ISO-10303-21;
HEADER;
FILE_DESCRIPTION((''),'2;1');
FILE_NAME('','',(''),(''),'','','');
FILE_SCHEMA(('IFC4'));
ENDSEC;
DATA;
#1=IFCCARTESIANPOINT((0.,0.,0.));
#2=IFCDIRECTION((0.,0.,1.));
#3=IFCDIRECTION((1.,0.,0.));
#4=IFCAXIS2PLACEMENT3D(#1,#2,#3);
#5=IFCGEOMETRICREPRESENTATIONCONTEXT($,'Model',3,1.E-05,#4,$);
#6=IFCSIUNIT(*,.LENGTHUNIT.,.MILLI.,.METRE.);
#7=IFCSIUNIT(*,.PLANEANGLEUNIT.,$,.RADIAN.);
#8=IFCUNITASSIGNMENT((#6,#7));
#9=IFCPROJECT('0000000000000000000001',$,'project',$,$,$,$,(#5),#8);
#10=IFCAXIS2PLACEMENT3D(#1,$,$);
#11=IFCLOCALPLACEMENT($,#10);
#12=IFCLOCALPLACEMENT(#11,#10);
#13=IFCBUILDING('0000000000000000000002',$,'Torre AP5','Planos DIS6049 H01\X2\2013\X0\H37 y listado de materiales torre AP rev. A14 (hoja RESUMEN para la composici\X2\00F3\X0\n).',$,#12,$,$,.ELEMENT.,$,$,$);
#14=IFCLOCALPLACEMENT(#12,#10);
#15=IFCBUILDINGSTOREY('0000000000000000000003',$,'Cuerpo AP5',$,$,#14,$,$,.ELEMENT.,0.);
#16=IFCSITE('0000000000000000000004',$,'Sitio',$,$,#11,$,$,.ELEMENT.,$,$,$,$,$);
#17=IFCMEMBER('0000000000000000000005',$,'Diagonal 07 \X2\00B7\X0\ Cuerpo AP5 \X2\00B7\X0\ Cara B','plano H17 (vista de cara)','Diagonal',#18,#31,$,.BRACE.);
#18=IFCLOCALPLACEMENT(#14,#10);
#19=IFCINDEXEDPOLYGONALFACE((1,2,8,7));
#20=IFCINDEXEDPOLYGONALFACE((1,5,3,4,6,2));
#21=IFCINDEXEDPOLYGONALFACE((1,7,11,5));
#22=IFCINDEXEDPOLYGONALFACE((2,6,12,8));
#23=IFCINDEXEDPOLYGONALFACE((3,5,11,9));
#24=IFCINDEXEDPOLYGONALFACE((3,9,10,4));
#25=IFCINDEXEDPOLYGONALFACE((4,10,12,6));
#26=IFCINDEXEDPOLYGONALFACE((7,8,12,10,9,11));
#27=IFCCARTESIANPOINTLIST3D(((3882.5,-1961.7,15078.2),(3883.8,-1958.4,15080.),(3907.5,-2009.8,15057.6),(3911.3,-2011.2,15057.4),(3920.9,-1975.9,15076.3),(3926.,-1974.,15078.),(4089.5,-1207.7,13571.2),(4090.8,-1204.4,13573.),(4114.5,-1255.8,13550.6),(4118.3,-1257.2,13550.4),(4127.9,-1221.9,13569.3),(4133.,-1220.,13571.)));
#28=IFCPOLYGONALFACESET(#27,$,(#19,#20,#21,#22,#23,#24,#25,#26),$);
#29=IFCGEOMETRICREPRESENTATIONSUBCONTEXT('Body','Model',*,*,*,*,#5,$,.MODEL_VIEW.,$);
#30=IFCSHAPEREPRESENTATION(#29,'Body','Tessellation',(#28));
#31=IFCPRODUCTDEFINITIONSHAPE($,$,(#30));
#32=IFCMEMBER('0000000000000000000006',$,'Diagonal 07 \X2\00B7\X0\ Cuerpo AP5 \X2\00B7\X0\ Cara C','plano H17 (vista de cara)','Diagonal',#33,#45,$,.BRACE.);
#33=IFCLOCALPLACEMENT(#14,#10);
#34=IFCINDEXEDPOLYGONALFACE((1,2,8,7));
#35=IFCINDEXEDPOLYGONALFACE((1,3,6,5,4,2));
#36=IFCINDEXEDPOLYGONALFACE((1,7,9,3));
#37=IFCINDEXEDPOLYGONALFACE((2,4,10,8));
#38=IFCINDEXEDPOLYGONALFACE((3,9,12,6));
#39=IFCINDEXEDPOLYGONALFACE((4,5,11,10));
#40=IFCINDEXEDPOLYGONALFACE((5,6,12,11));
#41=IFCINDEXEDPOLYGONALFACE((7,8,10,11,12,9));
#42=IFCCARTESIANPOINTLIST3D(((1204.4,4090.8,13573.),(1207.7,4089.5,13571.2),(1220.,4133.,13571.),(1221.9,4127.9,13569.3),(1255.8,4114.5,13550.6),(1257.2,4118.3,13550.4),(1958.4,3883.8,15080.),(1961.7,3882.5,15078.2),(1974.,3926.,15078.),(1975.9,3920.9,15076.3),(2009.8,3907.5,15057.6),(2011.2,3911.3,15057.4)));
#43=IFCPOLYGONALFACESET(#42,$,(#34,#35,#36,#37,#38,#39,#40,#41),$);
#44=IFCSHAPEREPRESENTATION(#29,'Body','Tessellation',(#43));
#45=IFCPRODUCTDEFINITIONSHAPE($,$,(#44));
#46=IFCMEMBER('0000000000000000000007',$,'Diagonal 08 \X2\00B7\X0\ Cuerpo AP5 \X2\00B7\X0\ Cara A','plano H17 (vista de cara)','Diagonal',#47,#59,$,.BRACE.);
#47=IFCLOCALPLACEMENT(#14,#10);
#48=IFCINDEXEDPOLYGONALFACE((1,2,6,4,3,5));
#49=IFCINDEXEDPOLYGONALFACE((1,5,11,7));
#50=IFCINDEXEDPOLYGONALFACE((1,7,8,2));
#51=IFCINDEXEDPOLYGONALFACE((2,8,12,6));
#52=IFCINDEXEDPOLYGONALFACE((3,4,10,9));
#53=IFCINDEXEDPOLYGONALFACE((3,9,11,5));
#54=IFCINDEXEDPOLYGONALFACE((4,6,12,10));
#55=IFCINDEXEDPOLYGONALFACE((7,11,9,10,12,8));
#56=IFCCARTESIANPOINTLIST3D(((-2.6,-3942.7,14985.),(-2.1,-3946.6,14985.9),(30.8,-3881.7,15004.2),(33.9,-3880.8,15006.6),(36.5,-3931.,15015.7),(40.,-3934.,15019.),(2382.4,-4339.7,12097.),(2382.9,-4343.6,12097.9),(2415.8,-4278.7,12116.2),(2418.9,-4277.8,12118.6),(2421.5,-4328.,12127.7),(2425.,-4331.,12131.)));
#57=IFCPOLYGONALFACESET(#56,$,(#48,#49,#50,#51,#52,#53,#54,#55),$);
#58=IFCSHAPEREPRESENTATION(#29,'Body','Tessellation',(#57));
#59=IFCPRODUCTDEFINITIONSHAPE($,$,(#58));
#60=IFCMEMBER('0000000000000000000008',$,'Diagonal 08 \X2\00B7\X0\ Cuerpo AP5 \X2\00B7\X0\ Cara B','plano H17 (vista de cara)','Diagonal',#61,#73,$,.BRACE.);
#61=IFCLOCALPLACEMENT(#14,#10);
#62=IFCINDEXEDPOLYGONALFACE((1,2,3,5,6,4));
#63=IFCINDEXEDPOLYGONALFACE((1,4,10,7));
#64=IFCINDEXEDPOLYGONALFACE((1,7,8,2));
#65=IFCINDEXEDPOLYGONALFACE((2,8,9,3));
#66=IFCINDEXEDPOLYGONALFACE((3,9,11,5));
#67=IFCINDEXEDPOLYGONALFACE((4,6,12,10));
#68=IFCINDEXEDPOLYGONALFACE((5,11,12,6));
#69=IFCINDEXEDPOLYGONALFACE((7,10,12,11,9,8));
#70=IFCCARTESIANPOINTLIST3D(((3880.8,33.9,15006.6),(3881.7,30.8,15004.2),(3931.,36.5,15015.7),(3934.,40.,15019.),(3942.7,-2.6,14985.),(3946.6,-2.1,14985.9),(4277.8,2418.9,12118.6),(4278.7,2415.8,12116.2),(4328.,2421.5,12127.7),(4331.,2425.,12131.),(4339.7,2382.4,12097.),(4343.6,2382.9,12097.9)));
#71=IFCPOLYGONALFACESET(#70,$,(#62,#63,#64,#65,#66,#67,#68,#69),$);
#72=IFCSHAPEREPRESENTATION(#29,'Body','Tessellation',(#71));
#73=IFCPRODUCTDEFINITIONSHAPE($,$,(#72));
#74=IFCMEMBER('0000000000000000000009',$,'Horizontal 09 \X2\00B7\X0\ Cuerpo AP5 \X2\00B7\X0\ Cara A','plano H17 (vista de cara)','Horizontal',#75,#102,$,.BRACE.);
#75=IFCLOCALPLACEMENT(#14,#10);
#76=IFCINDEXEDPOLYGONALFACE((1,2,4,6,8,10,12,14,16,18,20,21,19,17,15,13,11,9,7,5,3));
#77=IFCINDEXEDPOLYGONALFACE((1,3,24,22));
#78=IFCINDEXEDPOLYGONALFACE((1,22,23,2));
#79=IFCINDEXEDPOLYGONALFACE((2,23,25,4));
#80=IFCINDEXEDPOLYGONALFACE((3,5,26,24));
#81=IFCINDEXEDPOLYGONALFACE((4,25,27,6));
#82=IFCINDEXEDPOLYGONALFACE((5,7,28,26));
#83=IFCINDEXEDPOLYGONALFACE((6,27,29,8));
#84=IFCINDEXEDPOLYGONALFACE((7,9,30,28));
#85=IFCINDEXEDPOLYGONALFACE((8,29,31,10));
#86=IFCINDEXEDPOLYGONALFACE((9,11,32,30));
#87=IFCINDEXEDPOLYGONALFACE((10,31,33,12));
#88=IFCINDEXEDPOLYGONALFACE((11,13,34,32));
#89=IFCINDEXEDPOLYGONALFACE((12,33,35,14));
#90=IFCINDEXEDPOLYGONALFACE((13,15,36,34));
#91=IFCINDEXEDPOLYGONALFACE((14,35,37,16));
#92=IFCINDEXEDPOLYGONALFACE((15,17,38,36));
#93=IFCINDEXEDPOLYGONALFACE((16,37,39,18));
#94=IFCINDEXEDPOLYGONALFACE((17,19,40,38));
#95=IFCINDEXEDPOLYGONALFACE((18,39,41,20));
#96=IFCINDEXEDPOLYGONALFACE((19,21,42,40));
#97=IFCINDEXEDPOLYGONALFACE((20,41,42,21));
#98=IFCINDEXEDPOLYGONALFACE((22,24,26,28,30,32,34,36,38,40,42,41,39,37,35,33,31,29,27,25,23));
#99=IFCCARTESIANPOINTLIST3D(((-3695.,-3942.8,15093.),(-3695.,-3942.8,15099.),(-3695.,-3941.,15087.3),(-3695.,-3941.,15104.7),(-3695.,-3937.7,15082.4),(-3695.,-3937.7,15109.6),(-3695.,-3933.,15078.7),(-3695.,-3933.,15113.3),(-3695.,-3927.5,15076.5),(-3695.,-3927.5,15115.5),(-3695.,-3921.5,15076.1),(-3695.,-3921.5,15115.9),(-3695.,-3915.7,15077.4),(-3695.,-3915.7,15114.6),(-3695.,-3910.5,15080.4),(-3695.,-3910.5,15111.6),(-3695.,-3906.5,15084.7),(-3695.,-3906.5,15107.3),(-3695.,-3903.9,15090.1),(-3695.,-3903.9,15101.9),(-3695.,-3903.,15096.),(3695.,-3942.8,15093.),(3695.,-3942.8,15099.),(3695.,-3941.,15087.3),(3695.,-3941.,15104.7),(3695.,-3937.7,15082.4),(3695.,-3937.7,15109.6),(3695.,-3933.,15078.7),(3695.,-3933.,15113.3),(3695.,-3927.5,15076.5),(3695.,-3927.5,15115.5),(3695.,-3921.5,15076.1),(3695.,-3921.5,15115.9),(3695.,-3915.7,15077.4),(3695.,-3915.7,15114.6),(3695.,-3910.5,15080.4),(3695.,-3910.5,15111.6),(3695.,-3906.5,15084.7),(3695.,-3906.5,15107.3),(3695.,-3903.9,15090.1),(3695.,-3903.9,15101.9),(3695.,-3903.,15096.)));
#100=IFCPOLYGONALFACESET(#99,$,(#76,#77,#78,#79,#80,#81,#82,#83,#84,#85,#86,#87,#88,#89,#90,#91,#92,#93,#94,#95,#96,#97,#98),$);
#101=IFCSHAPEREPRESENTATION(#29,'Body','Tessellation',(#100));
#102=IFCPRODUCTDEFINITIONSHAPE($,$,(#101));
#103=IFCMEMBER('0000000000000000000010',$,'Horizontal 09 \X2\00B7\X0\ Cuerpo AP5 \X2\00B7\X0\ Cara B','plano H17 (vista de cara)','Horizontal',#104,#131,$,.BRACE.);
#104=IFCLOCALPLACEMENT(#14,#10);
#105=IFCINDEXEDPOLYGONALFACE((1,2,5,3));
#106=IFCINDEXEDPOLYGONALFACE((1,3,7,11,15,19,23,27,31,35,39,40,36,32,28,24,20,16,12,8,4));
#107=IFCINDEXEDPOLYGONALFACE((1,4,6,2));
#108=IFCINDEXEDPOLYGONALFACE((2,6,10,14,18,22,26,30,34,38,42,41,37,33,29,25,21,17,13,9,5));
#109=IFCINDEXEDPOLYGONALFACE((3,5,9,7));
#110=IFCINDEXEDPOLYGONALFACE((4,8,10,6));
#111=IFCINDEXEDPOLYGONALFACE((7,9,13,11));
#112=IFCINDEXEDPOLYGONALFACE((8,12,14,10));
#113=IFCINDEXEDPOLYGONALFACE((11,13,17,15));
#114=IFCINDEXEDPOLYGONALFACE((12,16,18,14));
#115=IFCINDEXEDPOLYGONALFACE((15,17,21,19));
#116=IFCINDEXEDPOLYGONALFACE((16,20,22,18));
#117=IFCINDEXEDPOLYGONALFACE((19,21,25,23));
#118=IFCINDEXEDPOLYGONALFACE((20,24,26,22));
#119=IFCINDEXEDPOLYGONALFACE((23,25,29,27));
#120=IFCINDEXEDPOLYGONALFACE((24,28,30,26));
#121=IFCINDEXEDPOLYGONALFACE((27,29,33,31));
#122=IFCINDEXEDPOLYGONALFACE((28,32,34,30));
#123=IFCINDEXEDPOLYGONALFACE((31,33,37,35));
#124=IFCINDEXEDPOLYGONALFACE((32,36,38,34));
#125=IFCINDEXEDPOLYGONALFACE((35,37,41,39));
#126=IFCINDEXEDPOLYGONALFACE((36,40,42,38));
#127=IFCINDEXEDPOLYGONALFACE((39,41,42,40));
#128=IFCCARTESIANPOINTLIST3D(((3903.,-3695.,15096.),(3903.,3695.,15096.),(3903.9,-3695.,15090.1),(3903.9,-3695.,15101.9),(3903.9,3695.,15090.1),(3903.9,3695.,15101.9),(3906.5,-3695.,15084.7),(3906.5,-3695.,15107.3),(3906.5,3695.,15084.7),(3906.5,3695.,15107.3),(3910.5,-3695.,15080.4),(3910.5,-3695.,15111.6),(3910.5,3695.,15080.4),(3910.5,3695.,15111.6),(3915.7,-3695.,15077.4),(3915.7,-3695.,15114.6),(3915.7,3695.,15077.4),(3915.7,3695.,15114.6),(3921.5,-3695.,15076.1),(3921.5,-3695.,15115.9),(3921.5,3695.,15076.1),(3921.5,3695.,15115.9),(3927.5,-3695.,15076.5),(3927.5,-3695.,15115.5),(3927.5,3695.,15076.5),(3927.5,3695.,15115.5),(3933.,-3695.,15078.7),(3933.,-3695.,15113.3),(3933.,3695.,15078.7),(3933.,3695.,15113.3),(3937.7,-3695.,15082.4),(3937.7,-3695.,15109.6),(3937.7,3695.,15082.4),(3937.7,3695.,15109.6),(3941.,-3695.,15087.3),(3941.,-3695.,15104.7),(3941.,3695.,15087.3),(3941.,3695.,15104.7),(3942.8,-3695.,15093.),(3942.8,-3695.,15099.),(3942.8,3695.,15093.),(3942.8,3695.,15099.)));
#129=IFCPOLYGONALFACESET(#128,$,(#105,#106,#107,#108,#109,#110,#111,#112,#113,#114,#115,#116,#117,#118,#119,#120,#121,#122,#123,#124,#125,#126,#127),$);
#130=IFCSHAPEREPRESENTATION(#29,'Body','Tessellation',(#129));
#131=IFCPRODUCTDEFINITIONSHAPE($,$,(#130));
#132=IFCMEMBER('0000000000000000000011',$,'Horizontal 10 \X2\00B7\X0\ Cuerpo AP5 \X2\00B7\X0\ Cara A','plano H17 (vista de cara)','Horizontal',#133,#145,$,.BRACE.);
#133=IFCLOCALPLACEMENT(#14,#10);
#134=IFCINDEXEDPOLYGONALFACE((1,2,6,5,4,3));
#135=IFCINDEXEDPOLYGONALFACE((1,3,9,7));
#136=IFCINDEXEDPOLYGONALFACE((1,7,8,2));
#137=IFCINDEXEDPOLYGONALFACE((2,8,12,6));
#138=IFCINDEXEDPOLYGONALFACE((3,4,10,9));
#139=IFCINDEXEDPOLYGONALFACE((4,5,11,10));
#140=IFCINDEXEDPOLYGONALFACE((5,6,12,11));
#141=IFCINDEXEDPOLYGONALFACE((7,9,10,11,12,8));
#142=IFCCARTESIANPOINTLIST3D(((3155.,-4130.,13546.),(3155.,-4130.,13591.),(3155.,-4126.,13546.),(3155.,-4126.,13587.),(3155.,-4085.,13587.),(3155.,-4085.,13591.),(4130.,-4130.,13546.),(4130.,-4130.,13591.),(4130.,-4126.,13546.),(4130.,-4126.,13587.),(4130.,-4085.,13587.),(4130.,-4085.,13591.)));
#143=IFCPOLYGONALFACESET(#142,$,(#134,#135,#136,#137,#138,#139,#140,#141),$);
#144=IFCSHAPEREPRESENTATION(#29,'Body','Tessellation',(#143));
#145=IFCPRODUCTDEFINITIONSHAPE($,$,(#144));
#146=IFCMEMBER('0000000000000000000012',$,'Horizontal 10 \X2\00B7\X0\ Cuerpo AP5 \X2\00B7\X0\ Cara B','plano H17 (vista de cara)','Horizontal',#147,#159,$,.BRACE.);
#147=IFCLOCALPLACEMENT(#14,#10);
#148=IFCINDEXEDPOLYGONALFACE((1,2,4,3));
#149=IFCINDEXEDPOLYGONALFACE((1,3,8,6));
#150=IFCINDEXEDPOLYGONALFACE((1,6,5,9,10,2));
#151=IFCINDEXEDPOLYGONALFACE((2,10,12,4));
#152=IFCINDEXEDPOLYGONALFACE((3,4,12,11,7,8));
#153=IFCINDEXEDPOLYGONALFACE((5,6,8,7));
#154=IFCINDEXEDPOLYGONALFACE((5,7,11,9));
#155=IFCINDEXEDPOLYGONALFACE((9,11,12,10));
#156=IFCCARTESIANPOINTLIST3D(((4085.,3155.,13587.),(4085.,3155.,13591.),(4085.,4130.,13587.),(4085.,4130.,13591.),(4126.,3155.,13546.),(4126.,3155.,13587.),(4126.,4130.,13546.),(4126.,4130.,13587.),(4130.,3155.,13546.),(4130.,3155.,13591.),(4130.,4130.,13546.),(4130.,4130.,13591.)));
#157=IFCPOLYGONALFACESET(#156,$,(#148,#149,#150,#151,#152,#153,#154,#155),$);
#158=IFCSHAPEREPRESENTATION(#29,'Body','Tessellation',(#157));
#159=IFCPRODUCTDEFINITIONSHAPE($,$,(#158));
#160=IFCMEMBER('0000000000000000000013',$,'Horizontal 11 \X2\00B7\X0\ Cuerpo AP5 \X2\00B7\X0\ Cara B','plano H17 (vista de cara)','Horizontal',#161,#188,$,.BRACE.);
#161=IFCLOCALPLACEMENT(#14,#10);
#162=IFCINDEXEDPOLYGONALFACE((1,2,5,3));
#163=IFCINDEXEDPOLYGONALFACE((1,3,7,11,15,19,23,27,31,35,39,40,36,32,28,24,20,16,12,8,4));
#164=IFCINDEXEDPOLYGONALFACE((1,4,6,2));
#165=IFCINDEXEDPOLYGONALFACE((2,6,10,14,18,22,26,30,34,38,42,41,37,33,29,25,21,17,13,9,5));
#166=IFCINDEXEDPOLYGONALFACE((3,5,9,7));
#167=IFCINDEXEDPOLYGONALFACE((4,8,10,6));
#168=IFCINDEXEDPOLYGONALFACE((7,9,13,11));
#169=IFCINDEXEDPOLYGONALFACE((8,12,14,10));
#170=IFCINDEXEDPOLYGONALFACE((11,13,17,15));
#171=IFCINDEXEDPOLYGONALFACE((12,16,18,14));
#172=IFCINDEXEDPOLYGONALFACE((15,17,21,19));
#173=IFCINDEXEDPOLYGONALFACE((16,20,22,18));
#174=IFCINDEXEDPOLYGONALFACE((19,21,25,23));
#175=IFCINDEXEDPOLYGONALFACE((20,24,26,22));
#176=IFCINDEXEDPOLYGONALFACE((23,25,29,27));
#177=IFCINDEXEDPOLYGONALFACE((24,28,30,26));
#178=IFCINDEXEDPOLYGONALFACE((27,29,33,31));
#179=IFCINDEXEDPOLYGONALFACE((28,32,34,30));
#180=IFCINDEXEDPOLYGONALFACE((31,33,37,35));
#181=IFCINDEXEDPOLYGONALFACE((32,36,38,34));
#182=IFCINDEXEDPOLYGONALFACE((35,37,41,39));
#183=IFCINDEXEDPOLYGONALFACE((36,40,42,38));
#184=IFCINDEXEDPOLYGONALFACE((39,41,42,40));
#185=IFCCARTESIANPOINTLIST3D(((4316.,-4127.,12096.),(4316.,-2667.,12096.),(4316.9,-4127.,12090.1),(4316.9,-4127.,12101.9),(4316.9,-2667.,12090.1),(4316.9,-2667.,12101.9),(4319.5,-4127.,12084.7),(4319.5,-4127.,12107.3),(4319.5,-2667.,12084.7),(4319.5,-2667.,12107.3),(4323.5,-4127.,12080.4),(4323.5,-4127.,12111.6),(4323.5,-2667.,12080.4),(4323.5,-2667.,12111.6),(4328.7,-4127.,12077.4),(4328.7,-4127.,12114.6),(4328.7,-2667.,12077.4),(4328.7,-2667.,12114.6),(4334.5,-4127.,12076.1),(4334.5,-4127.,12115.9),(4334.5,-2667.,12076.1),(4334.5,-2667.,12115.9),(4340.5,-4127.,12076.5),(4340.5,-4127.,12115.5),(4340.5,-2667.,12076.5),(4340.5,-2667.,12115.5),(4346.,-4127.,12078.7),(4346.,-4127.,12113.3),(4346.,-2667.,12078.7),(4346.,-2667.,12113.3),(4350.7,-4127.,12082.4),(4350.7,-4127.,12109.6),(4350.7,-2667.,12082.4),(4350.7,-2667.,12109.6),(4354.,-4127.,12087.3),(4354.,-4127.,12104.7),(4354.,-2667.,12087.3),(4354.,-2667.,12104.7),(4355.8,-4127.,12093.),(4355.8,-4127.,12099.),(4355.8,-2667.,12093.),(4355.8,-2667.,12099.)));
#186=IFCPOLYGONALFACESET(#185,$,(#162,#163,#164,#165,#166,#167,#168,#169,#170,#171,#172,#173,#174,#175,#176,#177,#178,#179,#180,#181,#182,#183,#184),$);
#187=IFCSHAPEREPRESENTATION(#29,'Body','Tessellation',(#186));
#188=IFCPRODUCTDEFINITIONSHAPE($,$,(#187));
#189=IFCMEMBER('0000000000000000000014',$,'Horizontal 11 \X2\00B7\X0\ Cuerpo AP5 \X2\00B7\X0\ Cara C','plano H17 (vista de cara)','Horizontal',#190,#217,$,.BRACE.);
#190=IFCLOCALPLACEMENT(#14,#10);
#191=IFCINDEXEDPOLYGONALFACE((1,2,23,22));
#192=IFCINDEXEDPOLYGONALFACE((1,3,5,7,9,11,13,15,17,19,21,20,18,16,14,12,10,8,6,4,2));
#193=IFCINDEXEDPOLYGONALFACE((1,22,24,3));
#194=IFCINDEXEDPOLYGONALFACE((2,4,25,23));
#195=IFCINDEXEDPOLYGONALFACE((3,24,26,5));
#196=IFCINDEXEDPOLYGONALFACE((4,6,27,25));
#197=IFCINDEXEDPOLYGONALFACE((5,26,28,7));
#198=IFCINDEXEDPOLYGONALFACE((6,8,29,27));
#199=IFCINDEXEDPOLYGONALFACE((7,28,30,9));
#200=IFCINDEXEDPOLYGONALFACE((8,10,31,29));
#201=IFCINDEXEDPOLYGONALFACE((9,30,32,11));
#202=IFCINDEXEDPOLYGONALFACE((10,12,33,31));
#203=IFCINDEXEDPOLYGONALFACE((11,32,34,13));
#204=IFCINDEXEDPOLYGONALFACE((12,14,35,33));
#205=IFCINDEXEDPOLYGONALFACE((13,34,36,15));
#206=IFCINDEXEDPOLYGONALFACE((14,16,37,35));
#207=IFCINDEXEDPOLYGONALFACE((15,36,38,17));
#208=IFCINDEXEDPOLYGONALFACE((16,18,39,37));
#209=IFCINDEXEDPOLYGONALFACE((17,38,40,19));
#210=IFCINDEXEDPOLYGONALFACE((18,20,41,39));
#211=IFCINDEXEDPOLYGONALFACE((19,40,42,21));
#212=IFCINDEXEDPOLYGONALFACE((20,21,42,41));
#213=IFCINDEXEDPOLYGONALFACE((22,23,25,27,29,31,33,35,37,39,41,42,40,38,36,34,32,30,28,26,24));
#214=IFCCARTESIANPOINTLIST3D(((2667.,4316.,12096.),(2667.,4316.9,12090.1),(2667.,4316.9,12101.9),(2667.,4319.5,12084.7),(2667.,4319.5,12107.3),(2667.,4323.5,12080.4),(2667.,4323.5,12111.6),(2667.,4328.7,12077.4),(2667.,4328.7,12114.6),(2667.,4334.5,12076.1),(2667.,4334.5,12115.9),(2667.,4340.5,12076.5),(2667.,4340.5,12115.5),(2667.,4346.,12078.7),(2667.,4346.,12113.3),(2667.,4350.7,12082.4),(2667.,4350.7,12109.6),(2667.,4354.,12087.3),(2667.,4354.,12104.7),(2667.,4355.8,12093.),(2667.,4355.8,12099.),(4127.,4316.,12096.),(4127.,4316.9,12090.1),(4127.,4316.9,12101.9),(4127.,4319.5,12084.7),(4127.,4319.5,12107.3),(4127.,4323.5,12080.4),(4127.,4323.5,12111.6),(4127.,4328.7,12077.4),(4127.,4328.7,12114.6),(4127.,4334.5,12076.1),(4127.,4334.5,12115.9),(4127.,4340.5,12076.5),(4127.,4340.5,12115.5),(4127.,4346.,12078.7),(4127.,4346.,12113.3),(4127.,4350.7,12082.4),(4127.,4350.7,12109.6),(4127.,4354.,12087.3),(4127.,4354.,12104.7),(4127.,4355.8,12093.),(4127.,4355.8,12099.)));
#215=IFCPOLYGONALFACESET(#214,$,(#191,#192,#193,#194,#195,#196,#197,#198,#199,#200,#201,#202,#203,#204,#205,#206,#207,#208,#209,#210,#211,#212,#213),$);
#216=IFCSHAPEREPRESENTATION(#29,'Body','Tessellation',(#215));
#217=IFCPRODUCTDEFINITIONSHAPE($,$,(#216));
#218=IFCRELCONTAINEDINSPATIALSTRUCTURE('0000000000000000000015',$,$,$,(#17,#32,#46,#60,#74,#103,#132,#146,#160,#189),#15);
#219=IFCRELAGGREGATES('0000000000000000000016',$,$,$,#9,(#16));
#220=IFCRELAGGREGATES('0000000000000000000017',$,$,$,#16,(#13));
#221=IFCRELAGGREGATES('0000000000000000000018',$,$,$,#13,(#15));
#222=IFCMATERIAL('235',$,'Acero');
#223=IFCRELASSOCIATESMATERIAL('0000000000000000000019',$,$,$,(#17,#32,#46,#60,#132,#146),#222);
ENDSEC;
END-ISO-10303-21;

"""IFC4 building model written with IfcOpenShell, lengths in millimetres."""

from ifc_helpers import new_model, si_unit, frame, frame_2d, origin, origin_with_axes, place, context, subcontext, project, spatial, circle, l_section, extrude, material, element, save


model = new_model("IFC4")

# Units and contexts
model_context = context("Model", 3, precision=1e-05, world=origin_with_axes())
body_context = subcontext(model_context, "Body", "Model", "MODEL_VIEW")
ifc_project = project(units=[si_unit("LENGTHUNIT", "METRE", prefix="MILLI"), si_unit("PLANEANGLEUNIT", "RADIAN")], contexts=[model_context])

# Site, building, storey
site_placement = place(None, origin())
site = spatial("IfcSite", under=ifc_project, at=site_placement, Name="Sitio", CompositionType="ELEMENT")
building_placement = place(site_placement, origin())
building = spatial("IfcBuilding", under=site, at=building_placement, Name="Torre AP5", Description="Planos DIS6049 H01–H37 y listado de materiales torre AP rev. A14 (hoja RESUMEN para la composición).", CompositionType="ELEMENT")
storey_placement = place(building_placement, origin())
storey = spatial("IfcBuildingStorey", under=building, at=storey_placement, Name="Cuerpo AP5", CompositionType="ELEMENT", Elevation=0.0)

# Members
ifc_material_1 = material(Name="235", Category="Acero")
for number, where, z_axis, x_axis, name in (
    (1, (4133.0, -1220.0, 13571.0), (-0.121925, -0.444113, 0.887636), (-0.936966, 0.346552, 0.04469), "Diagonal 07 · Cuerpo AP5 · Cara B"),
    (2, (1220.0, 4133.0, 13571.0), (0.444113, -0.121925, 0.887636), (-0.346552, -0.936966, 0.04469), "Diagonal 07 · Cuerpo AP5 · Cara C"),
):
    element("IfcMember", number, at=place(storey_placement, frame(where, z_axis=z_axis, x_axis=x_axis)), inside=storey, material=ifc_material_1, Name=name, Description="plano H17 (vista de cara)", ObjectType="Diagonal", PredefinedType="BRACE", context=body_context, shape_type="SweptSolid", body=[
        extrude(l_section(Depth=45.0, Width=45.0, Thickness=4.0, at=frame_2d((22.5, 22.5))), None, (0.0, 0.0, 1.0), 1697.8),
    ])
for number, where, z_axis, x_axis, name in (
    (3, (2425.0, -4331.0, 12131.0), (-0.633217, 0.105403, 0.766763), (-0.111785, 0.967841, -0.22536), "Diagonal 08 · Cuerpo AP5 · Cara A"),
    (4, (4331.0, 2425.0, 12131.0), (-0.105403, -0.633217, 0.766763), (-0.967841, -0.111785, -0.22536), "Diagonal 08 · Cuerpo AP5 · Cara B"),
):
    element("IfcMember", number, at=place(storey_placement, frame(where, z_axis=z_axis, x_axis=x_axis)), inside=storey, material=ifc_material_1, Name=name, Description="plano H17 (vista de cara)", ObjectType="Diagonal", PredefinedType="BRACE", context=body_context, shape_type="SweptSolid", body=[
        extrude(l_section(Depth=55.0, Width=55.0, Thickness=4.0, at=frame_2d((27.5, 27.5))), None, (0.0, 0.0, 1.0), 3766.5),
    ])
for number, where, z_axis, x_axis, name in (
    (5, (3695.0, -3923.0, 15096.0), (-1.0, 0.0, 0.0), (0.0, 1.0, 0.0), "Horizontal 09 · Cuerpo AP5 · Cara A"),
    (6, (3923.0, 3695.0, 15096.0), (0.0, -1.0, 0.0), (-1.0, 0.0, 0.0), "Horizontal 09 · Cuerpo AP5 · Cara B"),
):
    element("IfcMember", number, at=place(storey_placement, frame(where, z_axis=z_axis, x_axis=x_axis)), inside=storey, Name=name, Description="plano H17 (vista de cara)", ObjectType="Horizontal", PredefinedType="BRACE", context=body_context, shape_type="SweptSolid", body=[
        extrude(circle(Radius=20.0), None, (0.0, 0.0, 1.0), 7390.0),
    ])
for number, where, z_axis, x_axis, name in (
    (7, (4130.0, -4130.0, 13591.0), (-1.0, 0.0, 0.0), (0.0, 1.0, 0.0), "Horizontal 10 · Cuerpo AP5 · Cara A"),
    (8, (4130.0, 4130.0, 13591.0), (0.0, -1.0, 0.0), (-1.0, 0.0, 0.0), "Horizontal 10 · Cuerpo AP5 · Cara B"),
):
    element("IfcMember", number, at=place(storey_placement, frame(where, z_axis=z_axis, x_axis=x_axis)), inside=storey, material=ifc_material_1, Name=name, Description="plano H17 (vista de cara)", ObjectType="Horizontal", PredefinedType="BRACE", context=body_context, shape_type="SweptSolid", body=[
        extrude(l_section(Depth=45.0, Width=45.0, Thickness=4.0, at=frame_2d((22.5, 22.5))), None, (0.0, 0.0, 1.0), 975.0),
    ])
for number, where, z_axis, x_axis, name in (
    (9, (4336.0, -2667.0, 12096.0), (0.0, -1.0, 0.0), (-1.0, 0.0, 0.0), "Horizontal 11 · Cuerpo AP5 · Cara B"),
    (10, (2667.0, 4336.0, 12096.0), (1.0, 0.0, 0.0), (0.0, -1.0, 0.0), "Horizontal 11 · Cuerpo AP5 · Cara C"),
):
    element("IfcMember", number, at=place(storey_placement, frame(where, z_axis=z_axis, x_axis=x_axis)), inside=storey, Name=name, Description="plano H17 (vista de cara)", ObjectType="Horizontal", PredefinedType="BRACE", context=body_context, shape_type="SweptSolid", body=[
        extrude(circle(Radius=20.0), None, (0.0, 0.0, 1.0), 1460.0),
    ])

save(model, "model.ifc")
